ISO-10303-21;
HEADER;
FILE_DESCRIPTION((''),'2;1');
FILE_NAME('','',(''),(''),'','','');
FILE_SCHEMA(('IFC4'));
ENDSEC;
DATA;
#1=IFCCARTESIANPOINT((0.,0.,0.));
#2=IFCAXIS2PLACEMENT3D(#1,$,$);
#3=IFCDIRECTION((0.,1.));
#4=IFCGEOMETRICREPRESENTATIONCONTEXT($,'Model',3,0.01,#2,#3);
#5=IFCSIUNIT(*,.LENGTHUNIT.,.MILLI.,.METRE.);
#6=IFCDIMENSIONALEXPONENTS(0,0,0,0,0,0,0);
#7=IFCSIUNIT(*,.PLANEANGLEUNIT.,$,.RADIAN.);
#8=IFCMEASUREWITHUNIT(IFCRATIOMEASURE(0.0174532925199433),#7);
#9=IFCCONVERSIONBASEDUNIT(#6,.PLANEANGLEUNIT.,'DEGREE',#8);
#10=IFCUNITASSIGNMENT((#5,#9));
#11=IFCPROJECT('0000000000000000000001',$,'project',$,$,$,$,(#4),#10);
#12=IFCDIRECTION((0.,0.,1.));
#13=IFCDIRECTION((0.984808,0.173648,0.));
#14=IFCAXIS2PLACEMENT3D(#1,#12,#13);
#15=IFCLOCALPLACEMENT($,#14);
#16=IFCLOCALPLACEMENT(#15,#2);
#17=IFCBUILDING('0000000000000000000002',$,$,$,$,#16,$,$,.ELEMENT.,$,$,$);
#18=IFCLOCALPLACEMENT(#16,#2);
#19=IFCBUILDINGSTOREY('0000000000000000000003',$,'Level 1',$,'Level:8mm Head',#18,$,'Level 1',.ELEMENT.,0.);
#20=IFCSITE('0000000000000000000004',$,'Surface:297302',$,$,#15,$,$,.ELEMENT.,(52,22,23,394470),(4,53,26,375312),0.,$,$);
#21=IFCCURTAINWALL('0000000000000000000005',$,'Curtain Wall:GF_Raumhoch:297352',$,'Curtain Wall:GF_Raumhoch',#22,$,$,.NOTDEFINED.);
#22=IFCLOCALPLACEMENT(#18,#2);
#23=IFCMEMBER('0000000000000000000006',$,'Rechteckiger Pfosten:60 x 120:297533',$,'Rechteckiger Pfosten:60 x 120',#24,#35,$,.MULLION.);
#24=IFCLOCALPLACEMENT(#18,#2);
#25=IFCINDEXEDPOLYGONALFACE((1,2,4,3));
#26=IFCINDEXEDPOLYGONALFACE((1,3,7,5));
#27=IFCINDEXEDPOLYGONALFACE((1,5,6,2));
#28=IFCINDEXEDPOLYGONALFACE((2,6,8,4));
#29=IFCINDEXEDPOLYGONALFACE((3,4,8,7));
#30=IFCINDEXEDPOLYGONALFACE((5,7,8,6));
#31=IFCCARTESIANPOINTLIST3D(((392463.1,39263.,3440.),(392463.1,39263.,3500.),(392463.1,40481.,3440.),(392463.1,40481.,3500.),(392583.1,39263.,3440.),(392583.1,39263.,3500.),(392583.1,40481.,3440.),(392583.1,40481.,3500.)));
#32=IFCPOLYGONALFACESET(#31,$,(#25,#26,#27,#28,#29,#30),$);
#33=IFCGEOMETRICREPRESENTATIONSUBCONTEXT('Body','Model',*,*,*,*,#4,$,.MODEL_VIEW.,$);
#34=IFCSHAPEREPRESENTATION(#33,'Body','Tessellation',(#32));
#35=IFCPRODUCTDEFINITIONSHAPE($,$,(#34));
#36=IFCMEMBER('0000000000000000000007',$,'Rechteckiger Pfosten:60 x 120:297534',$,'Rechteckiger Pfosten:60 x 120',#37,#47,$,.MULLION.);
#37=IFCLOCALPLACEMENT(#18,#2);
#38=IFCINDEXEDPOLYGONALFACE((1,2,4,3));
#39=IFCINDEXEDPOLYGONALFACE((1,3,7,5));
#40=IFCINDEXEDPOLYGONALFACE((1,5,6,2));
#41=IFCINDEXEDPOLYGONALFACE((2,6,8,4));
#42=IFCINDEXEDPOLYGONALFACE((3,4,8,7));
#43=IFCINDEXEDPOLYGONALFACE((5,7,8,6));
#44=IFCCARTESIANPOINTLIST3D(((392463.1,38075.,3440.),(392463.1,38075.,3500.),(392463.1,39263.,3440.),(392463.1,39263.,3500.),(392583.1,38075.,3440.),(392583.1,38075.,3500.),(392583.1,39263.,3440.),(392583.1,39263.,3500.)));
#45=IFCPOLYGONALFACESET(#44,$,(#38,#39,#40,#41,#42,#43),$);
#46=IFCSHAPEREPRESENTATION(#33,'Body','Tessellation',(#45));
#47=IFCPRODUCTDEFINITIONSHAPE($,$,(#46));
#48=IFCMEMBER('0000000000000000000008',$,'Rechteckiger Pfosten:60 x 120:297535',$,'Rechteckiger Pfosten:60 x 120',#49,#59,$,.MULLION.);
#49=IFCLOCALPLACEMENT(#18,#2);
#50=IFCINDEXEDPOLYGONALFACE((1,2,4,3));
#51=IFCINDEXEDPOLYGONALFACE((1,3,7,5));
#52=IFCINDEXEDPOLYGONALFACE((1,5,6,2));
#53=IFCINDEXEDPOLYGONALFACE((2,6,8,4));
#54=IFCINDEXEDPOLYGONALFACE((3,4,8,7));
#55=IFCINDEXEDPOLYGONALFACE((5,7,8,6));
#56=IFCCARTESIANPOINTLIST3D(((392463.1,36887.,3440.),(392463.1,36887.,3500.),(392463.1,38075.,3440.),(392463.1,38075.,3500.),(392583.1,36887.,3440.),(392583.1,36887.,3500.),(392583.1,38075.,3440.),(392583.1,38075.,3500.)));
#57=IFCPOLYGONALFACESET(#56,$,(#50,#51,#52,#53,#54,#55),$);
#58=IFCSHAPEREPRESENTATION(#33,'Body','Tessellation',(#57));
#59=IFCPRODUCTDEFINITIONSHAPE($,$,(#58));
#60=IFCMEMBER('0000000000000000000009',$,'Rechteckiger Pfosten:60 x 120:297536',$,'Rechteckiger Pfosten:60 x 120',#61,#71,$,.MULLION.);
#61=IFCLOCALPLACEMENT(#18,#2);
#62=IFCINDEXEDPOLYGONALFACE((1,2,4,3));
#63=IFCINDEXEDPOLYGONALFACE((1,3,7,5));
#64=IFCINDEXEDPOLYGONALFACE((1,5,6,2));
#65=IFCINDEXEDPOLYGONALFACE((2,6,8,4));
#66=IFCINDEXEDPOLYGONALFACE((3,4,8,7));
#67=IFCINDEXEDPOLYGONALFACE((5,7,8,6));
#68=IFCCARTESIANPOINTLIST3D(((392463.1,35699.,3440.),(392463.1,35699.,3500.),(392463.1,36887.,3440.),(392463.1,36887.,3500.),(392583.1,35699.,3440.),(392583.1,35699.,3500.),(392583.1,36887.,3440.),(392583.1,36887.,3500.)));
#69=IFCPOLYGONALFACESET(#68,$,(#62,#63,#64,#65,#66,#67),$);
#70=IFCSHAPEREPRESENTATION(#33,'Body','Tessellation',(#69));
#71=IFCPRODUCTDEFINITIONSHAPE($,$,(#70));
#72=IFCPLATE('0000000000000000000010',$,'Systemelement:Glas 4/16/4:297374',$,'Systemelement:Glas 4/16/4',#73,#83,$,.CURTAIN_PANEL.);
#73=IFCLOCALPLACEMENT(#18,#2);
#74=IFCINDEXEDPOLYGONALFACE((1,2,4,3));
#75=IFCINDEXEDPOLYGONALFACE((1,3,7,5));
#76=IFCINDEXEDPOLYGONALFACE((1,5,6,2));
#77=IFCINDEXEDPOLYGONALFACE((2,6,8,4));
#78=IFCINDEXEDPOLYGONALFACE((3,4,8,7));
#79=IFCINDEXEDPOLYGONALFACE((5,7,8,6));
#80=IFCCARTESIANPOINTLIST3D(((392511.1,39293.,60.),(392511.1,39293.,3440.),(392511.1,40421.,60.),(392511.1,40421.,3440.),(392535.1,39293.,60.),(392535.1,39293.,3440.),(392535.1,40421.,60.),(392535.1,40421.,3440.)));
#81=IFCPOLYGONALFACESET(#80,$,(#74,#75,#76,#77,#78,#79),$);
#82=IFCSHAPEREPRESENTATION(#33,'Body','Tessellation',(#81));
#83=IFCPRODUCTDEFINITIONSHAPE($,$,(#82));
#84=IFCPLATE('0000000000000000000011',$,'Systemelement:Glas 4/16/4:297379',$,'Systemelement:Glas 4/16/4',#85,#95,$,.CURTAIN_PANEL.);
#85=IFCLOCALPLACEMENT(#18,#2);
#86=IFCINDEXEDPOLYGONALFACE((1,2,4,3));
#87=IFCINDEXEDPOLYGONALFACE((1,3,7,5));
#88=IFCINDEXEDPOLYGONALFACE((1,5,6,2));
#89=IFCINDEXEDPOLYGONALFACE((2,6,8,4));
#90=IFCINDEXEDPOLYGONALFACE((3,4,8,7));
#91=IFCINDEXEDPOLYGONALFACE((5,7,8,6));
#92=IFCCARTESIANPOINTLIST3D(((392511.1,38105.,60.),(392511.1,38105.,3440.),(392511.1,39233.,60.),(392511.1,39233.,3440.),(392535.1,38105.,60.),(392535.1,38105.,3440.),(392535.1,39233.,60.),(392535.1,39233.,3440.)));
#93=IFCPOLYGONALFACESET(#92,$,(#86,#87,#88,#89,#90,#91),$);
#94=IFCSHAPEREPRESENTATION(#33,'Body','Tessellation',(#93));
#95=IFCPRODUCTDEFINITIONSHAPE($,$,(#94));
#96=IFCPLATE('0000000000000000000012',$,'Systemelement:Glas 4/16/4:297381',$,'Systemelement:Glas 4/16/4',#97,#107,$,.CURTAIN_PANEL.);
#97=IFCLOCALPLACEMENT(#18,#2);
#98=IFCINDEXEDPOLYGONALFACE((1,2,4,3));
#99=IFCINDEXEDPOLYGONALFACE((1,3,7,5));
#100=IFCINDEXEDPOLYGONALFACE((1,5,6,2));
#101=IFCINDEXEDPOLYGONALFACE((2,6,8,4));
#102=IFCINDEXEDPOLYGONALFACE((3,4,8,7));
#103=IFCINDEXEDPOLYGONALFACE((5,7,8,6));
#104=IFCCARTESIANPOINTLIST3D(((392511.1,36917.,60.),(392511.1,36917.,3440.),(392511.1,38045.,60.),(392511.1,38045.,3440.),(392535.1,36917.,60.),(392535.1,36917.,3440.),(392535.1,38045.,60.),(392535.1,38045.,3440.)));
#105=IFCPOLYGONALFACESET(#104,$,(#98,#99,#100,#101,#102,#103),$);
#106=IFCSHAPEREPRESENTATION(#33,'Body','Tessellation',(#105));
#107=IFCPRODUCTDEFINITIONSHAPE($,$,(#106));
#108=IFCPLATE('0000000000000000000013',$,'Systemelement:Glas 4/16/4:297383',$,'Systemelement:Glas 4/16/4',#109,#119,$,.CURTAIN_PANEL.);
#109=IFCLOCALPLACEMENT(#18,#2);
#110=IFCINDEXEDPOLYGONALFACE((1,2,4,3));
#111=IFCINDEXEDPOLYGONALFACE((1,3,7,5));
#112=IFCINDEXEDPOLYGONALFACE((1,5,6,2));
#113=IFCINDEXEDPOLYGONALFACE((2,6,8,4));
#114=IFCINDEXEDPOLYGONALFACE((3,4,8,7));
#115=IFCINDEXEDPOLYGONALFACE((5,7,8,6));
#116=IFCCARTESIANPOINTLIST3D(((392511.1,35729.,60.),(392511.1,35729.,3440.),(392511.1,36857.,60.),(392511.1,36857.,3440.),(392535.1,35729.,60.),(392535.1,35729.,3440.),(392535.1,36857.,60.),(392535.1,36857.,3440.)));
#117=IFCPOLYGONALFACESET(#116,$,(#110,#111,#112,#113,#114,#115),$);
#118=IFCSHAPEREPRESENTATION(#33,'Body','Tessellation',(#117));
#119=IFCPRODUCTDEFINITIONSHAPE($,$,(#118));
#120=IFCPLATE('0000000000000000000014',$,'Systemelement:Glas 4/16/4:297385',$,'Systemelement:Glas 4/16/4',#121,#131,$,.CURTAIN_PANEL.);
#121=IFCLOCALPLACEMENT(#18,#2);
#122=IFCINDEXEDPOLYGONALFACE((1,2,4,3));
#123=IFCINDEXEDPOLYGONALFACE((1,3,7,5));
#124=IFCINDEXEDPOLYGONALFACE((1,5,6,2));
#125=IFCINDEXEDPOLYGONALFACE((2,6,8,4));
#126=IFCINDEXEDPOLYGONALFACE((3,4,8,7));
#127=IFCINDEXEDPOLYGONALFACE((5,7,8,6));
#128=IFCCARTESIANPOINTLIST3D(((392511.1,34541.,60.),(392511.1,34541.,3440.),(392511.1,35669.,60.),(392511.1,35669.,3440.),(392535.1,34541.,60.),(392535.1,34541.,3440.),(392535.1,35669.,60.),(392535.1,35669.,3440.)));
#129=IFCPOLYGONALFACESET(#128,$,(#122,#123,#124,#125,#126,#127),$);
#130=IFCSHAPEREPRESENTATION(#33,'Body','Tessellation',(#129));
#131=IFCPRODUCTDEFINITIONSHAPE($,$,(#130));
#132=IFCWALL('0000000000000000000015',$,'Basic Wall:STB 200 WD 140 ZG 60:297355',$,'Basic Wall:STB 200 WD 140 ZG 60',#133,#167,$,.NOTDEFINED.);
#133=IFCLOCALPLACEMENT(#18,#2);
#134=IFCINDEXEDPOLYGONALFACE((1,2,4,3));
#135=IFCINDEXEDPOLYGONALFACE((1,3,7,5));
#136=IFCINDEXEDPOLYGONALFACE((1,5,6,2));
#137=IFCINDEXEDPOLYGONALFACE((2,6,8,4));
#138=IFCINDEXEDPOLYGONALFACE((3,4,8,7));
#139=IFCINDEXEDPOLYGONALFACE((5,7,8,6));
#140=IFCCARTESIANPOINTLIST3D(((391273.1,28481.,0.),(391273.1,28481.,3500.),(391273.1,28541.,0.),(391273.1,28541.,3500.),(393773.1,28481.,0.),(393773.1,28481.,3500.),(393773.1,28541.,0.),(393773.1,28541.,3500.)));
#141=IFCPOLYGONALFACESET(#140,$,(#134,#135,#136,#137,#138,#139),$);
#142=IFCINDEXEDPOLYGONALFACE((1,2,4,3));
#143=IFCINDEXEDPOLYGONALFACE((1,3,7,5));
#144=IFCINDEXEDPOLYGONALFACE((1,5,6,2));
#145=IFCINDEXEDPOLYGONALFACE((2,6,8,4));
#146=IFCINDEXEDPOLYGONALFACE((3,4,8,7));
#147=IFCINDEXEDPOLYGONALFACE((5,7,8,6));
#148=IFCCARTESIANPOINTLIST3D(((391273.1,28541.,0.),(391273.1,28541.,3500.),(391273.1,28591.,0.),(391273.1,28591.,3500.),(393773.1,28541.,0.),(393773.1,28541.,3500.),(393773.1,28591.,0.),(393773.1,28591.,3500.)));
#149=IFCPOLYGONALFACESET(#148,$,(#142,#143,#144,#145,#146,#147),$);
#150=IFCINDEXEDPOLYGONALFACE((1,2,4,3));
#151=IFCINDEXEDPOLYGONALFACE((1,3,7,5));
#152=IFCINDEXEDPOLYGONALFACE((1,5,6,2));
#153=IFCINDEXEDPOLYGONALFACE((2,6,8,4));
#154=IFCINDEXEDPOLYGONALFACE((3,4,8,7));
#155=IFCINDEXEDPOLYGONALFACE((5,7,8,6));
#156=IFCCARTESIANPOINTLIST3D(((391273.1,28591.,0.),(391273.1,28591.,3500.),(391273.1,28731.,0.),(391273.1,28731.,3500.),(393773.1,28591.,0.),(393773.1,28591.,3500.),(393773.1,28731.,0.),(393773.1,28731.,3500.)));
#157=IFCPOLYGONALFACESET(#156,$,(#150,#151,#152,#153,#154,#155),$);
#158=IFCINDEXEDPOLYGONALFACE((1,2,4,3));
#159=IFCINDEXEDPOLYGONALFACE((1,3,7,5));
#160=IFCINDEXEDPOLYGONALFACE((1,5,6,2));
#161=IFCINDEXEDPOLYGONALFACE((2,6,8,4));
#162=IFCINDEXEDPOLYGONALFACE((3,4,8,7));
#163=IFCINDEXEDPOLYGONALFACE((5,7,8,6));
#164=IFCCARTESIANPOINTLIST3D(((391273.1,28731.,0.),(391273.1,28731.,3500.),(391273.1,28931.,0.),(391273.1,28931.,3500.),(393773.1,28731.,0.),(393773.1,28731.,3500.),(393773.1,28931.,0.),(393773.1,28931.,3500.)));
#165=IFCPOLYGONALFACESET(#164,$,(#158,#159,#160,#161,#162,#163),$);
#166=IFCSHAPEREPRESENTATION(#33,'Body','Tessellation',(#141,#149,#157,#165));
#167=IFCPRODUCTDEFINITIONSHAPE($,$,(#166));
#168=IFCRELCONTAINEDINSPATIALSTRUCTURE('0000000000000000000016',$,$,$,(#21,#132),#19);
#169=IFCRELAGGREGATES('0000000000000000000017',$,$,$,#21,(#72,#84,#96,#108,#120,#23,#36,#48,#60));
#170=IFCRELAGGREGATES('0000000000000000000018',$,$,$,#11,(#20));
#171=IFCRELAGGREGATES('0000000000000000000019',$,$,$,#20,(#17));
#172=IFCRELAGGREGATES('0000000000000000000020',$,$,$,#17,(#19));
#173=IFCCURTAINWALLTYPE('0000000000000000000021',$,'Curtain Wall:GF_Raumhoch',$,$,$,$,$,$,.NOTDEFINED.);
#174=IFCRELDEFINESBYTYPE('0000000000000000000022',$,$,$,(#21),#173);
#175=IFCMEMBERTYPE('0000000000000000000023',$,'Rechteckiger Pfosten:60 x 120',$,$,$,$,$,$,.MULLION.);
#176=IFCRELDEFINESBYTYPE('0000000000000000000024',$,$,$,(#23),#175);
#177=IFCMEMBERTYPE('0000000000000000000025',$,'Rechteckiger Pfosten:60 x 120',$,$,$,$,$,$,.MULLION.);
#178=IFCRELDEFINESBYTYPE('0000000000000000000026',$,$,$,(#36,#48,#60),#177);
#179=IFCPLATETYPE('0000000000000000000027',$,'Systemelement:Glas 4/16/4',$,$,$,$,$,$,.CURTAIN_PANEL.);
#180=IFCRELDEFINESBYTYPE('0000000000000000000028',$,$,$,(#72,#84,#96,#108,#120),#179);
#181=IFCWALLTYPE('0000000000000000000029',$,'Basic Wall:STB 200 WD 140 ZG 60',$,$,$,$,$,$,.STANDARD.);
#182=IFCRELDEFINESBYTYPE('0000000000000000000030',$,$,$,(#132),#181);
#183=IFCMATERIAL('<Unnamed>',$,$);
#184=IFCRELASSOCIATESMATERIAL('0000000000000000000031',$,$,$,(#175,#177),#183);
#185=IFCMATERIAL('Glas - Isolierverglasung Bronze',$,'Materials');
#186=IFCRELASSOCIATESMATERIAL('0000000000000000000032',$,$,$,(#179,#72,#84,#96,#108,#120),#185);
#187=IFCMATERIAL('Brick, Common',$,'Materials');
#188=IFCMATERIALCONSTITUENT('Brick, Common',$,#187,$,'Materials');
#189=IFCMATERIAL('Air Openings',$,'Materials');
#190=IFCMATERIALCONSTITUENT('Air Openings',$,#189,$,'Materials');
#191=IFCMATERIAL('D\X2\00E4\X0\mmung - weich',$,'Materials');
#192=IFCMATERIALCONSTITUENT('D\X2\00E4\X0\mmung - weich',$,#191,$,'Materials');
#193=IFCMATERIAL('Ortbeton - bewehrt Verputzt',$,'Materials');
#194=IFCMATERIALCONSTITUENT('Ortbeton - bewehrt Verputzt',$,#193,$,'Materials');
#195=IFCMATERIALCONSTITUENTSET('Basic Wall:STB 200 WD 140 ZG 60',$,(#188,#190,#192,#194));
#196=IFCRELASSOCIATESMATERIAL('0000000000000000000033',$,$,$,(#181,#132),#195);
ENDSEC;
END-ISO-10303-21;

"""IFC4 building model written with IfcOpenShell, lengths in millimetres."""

from ifc_helpers import new_model, entity, si_unit, converted_unit, direction, frame, origin, place, context, subcontext, project, spatial, indexed_curve, outline, extrude, source, transform, mapped, material, constituent, constituent_set, type_object, type_shapes, element, aggregate, save


model = new_model("IFC4")

# Units and contexts
model_context = context("Model", 3, precision=0.01, world=origin(), true_north=direction((0.0, 1.0)))
body_context = subcontext(model_context, "Body", "Model", "MODEL_VIEW")
ifc_project = project(units=[si_unit("LENGTHUNIT", "METRE", prefix="MILLI"), converted_unit("PLANEANGLEUNIT", "DEGREE", entity("IfcRatioMeasure", 0.0174532925199433), si_unit("PLANEANGLEUNIT", "RADIAN"), dimensions=[0, 0, 0, 0, 0, 0, 0])], contexts=[model_context])

# Site, building, storey
site_placement = place(None, frame((0.0, 0.0, 0.0), z_axis=(0.0, 0.0, 1.0), x_axis=(0.984808, 0.173648, 0.0)))
site = spatial("IfcSite", under=ifc_project, at=site_placement, Name="Surface:297302", CompositionType="ELEMENT", RefLatitude=(52, 22, 23, 394470), RefLongitude=(4, 53, 26, 375312), RefElevation=0.0)
building_placement = place(site_placement, origin())
building = spatial("IfcBuilding", under=site, at=building_placement, CompositionType="ELEMENT")
storey_placement = place(building_placement, origin())
storey = spatial("IfcBuildingStorey", under=building, at=storey_placement, Name="Level 1", ObjectType="Level:8mm Head", LongName="Level 1", CompositionType="ELEMENT", Elevation=0.0)

# Curtain wall, members
curtain_wall_type = type_object("IfcCurtainWallType", Name="Curtain Wall:GF_Raumhoch", PredefinedType="NOTDEFINED")
curtain_wall_placement = place(storey_placement, origin())
curtain_wall = element("IfcCurtainWall", 1, at=curtain_wall_placement, inside=storey, type_object=curtain_wall_type, Name="Curtain Wall:GF_Raumhoch:297352", ObjectType="Curtain Wall:GF_Raumhoch", PredefinedType="NOTDEFINED")
ifc_material_1 = material(Name="<Unnamed>")
member_type_1 = type_object("IfcMemberType", Name="Rechteckiger Pfosten:60 x 120", PredefinedType="MULLION", material=ifc_material_1)
shared_shape_1 = source(origin(), body_context, "Body", "SweptSolid", [
    extrude(outline(indexed_curve([(-60.0, -30.0), (60.0, -30.0), (60.0, 30.0), (-60.0, 30.0), (-60.0, -30.0)], self_intersect=False)), frame((-30.0, 0.0, -1218.0), z_axis=(0.0, 0.0, 1.0), x_axis=(0.0, -1.0, 0.0)), (0.0, 0.0, 1.0), 1218.0),
])
type_shapes(member_type_1, [shared_shape_1])
member_1_placement = place(curtain_wall_placement, frame((392523.1, 39263.0, 3500.0), z_axis=(0.0, -1.0, 0.0), x_axis=(0.0, 0.0, 1.0)))
member_1 = element("IfcMember", 2, at=member_1_placement, type_object=member_type_1, Name="Rechteckiger Pfosten:60 x 120:297533", ObjectType="Rechteckiger Pfosten:60 x 120", PredefinedType="MULLION", context=body_context, shape_type="MappedRepresentation", body=[
    mapped(shared_shape_1, transform((0.0, 0.0, 0.0), scale=1.0)),
])
member_type_2 = type_object("IfcMemberType", Name="Rechteckiger Pfosten:60 x 120", PredefinedType="MULLION", material=ifc_material_1)
shared_shape_2 = source(origin(), body_context, "Body", "SweptSolid", [
    extrude(outline(indexed_curve([(-60.0, -30.0), (60.0, -30.0), (60.0, 30.0), (-60.0, 30.0), (-60.0, -30.0)], self_intersect=False)), frame((-30.0, 0.0, -1188.0), z_axis=(0.0, 0.0, 1.0), x_axis=(0.0, -1.0, 0.0)), (0.0, 0.0, 1.0), 1188.0),
])
type_shapes(member_type_2, [shared_shape_2])
member_2_placement = place(curtain_wall_placement, frame((392523.1, 38075.0, 3500.0), z_axis=(0.0, -1.0, 0.0), x_axis=(0.0, 0.0, 1.0)))
member_2 = element("IfcMember", 3, at=member_2_placement, type_object=member_type_2, Name="Rechteckiger Pfosten:60 x 120:297534", ObjectType="Rechteckiger Pfosten:60 x 120", PredefinedType="MULLION", context=body_context, shape_type="MappedRepresentation", body=[
    mapped(shared_shape_2, transform((0.0, 0.0, 0.0), scale=1.0)),
])
member_3_placement = place(curtain_wall_placement, frame((392523.1, 36887.0, 3500.0), z_axis=(0.0, -1.0, 0.0), x_axis=(0.0, 0.0, 1.0)))
member_3 = element("IfcMember", 4, at=member_3_placement, type_object=member_type_2, Name="Rechteckiger Pfosten:60 x 120:297535", ObjectType="Rechteckiger Pfosten:60 x 120", PredefinedType="MULLION", context=body_context, shape_type="MappedRepresentation", body=[
    mapped(shared_shape_2, transform((0.0, 0.0, 0.0), scale=1.0)),
])
member_4_placement = place(curtain_wall_placement, frame((392523.1, 35699.0, 3500.0), z_axis=(0.0, -1.0, 0.0), x_axis=(0.0, 0.0, 1.0)))
member_4 = element("IfcMember", 5, at=member_4_placement, type_object=member_type_2, Name="Rechteckiger Pfosten:60 x 120:297536", ObjectType="Rechteckiger Pfosten:60 x 120", PredefinedType="MULLION", context=body_context, shape_type="MappedRepresentation", body=[
    mapped(shared_shape_2, transform((0.0, 0.0, 0.0), scale=1.0)),
])

# Plates
ifc_material_2 = material(Name="Glas - Isolierverglasung Bronze", Category="Materials")
plate_type = type_object("IfcPlateType", Name="Systemelement:Glas 4/16/4", PredefinedType="CURTAIN_PANEL", material=ifc_material_2)
shared_shape_3 = source(origin(), body_context, "Body", "SweptSolid", [
    extrude(outline(indexed_curve([(-12.0, -564.0), (12.0, -564.0), (12.0, 564.0), (-12.0, 564.0), (-12.0, -564.0)], self_intersect=False)), frame((0.0, 0.0, 0.0), z_axis=(0.0, 0.0, 1.0), x_axis=(0.0, 1.0, 0.0)), (0.0, 0.0, 1.0), 3380.0),
])
type_shapes(plate_type, [shared_shape_3])
plate_1_placement = place(curtain_wall_placement, frame((392523.1, 39857.0, 60.0), z_axis=(0.0, 0.0, 1.0), x_axis=(0.0, -1.0, 0.0)))
plate_1 = element("IfcPlate", 6, at=plate_1_placement, type_object=plate_type, material=ifc_material_2, Name="Systemelement:Glas 4/16/4:297374", ObjectType="Systemelement:Glas 4/16/4", PredefinedType="CURTAIN_PANEL", context=body_context, shape_type="MappedRepresentation", body=[
    mapped(shared_shape_3, transform((0.0, 0.0, 0.0), scale=1.0)),
])
plate_2_placement = place(curtain_wall_placement, frame((392523.1, 38669.0, 60.0), z_axis=(0.0, 0.0, 1.0), x_axis=(0.0, -1.0, 0.0)))
plate_2 = element("IfcPlate", 7, at=plate_2_placement, type_object=plate_type, material=ifc_material_2, Name="Systemelement:Glas 4/16/4:297379", ObjectType="Systemelement:Glas 4/16/4", PredefinedType="CURTAIN_PANEL", context=body_context, shape_type="MappedRepresentation", body=[
    mapped(shared_shape_3, transform((0.0, 0.0, 0.0), scale=1.0)),
])
plate_3_placement = place(curtain_wall_placement, frame((392523.1, 37481.0, 60.0), z_axis=(0.0, 0.0, 1.0), x_axis=(0.0, -1.0, 0.0)))
plate_3 = element("IfcPlate", 8, at=plate_3_placement, type_object=plate_type, material=ifc_material_2, Name="Systemelement:Glas 4/16/4:297381", ObjectType="Systemelement:Glas 4/16/4", PredefinedType="CURTAIN_PANEL", context=body_context, shape_type="MappedRepresentation", body=[
    mapped(shared_shape_3, transform((0.0, 0.0, 0.0), scale=1.0)),
])
plate_4_placement = place(curtain_wall_placement, frame((392523.1, 36293.0, 60.0), z_axis=(0.0, 0.0, 1.0), x_axis=(0.0, -1.0, 0.0)))
plate_4 = element("IfcPlate", 9, at=plate_4_placement, type_object=plate_type, material=ifc_material_2, Name="Systemelement:Glas 4/16/4:297383", ObjectType="Systemelement:Glas 4/16/4", PredefinedType="CURTAIN_PANEL", context=body_context, shape_type="MappedRepresentation", body=[
    mapped(shared_shape_3, transform((0.0, 0.0, 0.0), scale=1.0)),
])
plate_5_placement = place(curtain_wall_placement, frame((392523.1, 35105.0, 60.0), z_axis=(0.0, 0.0, 1.0), x_axis=(0.0, -1.0, 0.0)))
plate_5 = element("IfcPlate", 10, at=plate_5_placement, type_object=plate_type, material=ifc_material_2, Name="Systemelement:Glas 4/16/4:297385", ObjectType="Systemelement:Glas 4/16/4", PredefinedType="CURTAIN_PANEL", context=body_context, shape_type="MappedRepresentation", body=[
    mapped(shared_shape_3, transform((0.0, 0.0, 0.0), scale=1.0)),
])
aggregate(curtain_wall, [plate_1, plate_2, plate_3, plate_4, plate_5, member_1, member_2, member_3, member_4])

# Wall, openings
ifc_material_3 = material(Name="Brick, Common", Category="Materials")
ifc_constituent_1 = constituent(ifc_material_3, Name="Brick, Common", Category="Materials")
ifc_material_4 = material(Name="Air Openings", Category="Materials")
ifc_constituent_2 = constituent(ifc_material_4, Name="Air Openings", Category="Materials")
ifc_material_5 = material(Name="Dämmung - weich", Category="Materials")
ifc_constituent_3 = constituent(ifc_material_5, Name="Dämmung - weich", Category="Materials")
ifc_material_6 = material(Name="Ortbeton - bewehrt Verputzt", Category="Materials")
ifc_constituent_4 = constituent(ifc_material_6, Name="Ortbeton - bewehrt Verputzt", Category="Materials")
ifc_constituent_set_1 = constituent_set(constituents=[ifc_constituent_1, ifc_constituent_2, ifc_constituent_3, ifc_constituent_4], Name="Basic Wall:STB 200 WD 140 ZG 60")
wall_type = type_object("IfcWallType", Name="Basic Wall:STB 200 WD 140 ZG 60", PredefinedType="STANDARD", material=ifc_constituent_set_1)
wall_1_placement = place(storey_placement, frame((393773.1, 28706.0, 0.0), z_axis=(0.0, 0.0, 1.0), x_axis=(-1.0, 0.0, 0.0)))
wall_1 = element("IfcWall", 11, at=wall_1_placement, inside=storey, type_object=wall_type, material=ifc_constituent_set_1, Name="Basic Wall:STB 200 WD 140 ZG 60:297355", ObjectType="Basic Wall:STB 200 WD 140 ZG 60", PredefinedType="NOTDEFINED", context=body_context, shape_type="SweptSolid", body=[
    extrude(outline(indexed_curve([(-30.0, -1250.0), (30.0, -1250.0), (30.0, 1250.0), (-30.0, 1250.0), (-30.0, -1250.0)], self_intersect=False)), frame((1250.0, 195.0, 0.0), z_axis=(0.0, 0.0, 1.0), x_axis=(0.0, -1.0, 0.0)), (0.0, 0.0, 1.0), 3500.0),
    extrude(outline(indexed_curve([(-1250.0, -25.0), (1250.0, -25.0), (1250.0, 25.0), (-1250.0, 25.0), (-1250.0, -25.0)], self_intersect=False)), frame((1250.0, 140.0, 0.0), z_axis=(0.0, 0.0, 1.0), x_axis=(-1.0, 0.0, 0.0)), (0.0, 0.0, 1.0), 3500.0),
    extrude(outline(indexed_curve([(-1250.0, -70.0), (1250.0, -70.0), (1250.0, 70.0), (-1250.0, 70.0), (-1250.0, -70.0)], self_intersect=False)), frame((1250.0, 45.0, 0.0), z_axis=(0.0, 0.0, 1.0), x_axis=(-1.0, 0.0, 0.0)), (0.0, 0.0, 1.0), 3500.0),
    extrude(outline(indexed_curve([(-100.0, -1250.0), (100.0, -1250.0), (100.0, 1250.0), (-100.0, 1250.0), (-100.0, -1250.0)], self_intersect=False)), frame((1250.0, -125.0, 0.0), z_axis=(0.0, 0.0, 1.0), x_axis=(0.0, 1.0, 0.0)), (0.0, 0.0, 1.0), 3500.0),
])
opening_1_placement = place(wall_1_placement, frame((2500.0, -225.0, 0.0)))
element("IfcOpeningElement", 12, at=opening_1_placement, cuts=wall_1, PredefinedType="OPENING", context=body_context, shape_type="SweptSolid", body=[
    extrude(outline(indexed_curve([(3500.0, 1050.0), (0.0, 1050.0), (0.0, 0.0), (3500.0, 0.0), (3500.0, 1050.0)], self_intersect=False)), frame((0.0, 0.0, 0.0), z_axis=(0.0, 1.0, 0.0), x_axis=(0.0, 0.0, 1.0)), (0.0, 0.0, 1.0), 450.0),
])
opening_2_placement = place(wall_1_placement, frame((-1050.0, -225.0, 0.0)))
element("IfcOpeningElement", 13, at=opening_2_placement, cuts=wall_1, PredefinedType="OPENING", context=body_context, shape_type="SweptSolid", body=[
    extrude(outline(indexed_curve([(3500.0, 1050.0), (0.0, 1050.0), (0.0, 0.0), (3500.0, 0.0), (3500.0, 1050.0)], self_intersect=False)), frame((0.0, 0.0, 0.0), z_axis=(0.0, 1.0, 0.0), x_axis=(0.0, 0.0, 1.0)), (0.0, 0.0, 1.0), 450.0),
])

save(model, "model.ifc")
